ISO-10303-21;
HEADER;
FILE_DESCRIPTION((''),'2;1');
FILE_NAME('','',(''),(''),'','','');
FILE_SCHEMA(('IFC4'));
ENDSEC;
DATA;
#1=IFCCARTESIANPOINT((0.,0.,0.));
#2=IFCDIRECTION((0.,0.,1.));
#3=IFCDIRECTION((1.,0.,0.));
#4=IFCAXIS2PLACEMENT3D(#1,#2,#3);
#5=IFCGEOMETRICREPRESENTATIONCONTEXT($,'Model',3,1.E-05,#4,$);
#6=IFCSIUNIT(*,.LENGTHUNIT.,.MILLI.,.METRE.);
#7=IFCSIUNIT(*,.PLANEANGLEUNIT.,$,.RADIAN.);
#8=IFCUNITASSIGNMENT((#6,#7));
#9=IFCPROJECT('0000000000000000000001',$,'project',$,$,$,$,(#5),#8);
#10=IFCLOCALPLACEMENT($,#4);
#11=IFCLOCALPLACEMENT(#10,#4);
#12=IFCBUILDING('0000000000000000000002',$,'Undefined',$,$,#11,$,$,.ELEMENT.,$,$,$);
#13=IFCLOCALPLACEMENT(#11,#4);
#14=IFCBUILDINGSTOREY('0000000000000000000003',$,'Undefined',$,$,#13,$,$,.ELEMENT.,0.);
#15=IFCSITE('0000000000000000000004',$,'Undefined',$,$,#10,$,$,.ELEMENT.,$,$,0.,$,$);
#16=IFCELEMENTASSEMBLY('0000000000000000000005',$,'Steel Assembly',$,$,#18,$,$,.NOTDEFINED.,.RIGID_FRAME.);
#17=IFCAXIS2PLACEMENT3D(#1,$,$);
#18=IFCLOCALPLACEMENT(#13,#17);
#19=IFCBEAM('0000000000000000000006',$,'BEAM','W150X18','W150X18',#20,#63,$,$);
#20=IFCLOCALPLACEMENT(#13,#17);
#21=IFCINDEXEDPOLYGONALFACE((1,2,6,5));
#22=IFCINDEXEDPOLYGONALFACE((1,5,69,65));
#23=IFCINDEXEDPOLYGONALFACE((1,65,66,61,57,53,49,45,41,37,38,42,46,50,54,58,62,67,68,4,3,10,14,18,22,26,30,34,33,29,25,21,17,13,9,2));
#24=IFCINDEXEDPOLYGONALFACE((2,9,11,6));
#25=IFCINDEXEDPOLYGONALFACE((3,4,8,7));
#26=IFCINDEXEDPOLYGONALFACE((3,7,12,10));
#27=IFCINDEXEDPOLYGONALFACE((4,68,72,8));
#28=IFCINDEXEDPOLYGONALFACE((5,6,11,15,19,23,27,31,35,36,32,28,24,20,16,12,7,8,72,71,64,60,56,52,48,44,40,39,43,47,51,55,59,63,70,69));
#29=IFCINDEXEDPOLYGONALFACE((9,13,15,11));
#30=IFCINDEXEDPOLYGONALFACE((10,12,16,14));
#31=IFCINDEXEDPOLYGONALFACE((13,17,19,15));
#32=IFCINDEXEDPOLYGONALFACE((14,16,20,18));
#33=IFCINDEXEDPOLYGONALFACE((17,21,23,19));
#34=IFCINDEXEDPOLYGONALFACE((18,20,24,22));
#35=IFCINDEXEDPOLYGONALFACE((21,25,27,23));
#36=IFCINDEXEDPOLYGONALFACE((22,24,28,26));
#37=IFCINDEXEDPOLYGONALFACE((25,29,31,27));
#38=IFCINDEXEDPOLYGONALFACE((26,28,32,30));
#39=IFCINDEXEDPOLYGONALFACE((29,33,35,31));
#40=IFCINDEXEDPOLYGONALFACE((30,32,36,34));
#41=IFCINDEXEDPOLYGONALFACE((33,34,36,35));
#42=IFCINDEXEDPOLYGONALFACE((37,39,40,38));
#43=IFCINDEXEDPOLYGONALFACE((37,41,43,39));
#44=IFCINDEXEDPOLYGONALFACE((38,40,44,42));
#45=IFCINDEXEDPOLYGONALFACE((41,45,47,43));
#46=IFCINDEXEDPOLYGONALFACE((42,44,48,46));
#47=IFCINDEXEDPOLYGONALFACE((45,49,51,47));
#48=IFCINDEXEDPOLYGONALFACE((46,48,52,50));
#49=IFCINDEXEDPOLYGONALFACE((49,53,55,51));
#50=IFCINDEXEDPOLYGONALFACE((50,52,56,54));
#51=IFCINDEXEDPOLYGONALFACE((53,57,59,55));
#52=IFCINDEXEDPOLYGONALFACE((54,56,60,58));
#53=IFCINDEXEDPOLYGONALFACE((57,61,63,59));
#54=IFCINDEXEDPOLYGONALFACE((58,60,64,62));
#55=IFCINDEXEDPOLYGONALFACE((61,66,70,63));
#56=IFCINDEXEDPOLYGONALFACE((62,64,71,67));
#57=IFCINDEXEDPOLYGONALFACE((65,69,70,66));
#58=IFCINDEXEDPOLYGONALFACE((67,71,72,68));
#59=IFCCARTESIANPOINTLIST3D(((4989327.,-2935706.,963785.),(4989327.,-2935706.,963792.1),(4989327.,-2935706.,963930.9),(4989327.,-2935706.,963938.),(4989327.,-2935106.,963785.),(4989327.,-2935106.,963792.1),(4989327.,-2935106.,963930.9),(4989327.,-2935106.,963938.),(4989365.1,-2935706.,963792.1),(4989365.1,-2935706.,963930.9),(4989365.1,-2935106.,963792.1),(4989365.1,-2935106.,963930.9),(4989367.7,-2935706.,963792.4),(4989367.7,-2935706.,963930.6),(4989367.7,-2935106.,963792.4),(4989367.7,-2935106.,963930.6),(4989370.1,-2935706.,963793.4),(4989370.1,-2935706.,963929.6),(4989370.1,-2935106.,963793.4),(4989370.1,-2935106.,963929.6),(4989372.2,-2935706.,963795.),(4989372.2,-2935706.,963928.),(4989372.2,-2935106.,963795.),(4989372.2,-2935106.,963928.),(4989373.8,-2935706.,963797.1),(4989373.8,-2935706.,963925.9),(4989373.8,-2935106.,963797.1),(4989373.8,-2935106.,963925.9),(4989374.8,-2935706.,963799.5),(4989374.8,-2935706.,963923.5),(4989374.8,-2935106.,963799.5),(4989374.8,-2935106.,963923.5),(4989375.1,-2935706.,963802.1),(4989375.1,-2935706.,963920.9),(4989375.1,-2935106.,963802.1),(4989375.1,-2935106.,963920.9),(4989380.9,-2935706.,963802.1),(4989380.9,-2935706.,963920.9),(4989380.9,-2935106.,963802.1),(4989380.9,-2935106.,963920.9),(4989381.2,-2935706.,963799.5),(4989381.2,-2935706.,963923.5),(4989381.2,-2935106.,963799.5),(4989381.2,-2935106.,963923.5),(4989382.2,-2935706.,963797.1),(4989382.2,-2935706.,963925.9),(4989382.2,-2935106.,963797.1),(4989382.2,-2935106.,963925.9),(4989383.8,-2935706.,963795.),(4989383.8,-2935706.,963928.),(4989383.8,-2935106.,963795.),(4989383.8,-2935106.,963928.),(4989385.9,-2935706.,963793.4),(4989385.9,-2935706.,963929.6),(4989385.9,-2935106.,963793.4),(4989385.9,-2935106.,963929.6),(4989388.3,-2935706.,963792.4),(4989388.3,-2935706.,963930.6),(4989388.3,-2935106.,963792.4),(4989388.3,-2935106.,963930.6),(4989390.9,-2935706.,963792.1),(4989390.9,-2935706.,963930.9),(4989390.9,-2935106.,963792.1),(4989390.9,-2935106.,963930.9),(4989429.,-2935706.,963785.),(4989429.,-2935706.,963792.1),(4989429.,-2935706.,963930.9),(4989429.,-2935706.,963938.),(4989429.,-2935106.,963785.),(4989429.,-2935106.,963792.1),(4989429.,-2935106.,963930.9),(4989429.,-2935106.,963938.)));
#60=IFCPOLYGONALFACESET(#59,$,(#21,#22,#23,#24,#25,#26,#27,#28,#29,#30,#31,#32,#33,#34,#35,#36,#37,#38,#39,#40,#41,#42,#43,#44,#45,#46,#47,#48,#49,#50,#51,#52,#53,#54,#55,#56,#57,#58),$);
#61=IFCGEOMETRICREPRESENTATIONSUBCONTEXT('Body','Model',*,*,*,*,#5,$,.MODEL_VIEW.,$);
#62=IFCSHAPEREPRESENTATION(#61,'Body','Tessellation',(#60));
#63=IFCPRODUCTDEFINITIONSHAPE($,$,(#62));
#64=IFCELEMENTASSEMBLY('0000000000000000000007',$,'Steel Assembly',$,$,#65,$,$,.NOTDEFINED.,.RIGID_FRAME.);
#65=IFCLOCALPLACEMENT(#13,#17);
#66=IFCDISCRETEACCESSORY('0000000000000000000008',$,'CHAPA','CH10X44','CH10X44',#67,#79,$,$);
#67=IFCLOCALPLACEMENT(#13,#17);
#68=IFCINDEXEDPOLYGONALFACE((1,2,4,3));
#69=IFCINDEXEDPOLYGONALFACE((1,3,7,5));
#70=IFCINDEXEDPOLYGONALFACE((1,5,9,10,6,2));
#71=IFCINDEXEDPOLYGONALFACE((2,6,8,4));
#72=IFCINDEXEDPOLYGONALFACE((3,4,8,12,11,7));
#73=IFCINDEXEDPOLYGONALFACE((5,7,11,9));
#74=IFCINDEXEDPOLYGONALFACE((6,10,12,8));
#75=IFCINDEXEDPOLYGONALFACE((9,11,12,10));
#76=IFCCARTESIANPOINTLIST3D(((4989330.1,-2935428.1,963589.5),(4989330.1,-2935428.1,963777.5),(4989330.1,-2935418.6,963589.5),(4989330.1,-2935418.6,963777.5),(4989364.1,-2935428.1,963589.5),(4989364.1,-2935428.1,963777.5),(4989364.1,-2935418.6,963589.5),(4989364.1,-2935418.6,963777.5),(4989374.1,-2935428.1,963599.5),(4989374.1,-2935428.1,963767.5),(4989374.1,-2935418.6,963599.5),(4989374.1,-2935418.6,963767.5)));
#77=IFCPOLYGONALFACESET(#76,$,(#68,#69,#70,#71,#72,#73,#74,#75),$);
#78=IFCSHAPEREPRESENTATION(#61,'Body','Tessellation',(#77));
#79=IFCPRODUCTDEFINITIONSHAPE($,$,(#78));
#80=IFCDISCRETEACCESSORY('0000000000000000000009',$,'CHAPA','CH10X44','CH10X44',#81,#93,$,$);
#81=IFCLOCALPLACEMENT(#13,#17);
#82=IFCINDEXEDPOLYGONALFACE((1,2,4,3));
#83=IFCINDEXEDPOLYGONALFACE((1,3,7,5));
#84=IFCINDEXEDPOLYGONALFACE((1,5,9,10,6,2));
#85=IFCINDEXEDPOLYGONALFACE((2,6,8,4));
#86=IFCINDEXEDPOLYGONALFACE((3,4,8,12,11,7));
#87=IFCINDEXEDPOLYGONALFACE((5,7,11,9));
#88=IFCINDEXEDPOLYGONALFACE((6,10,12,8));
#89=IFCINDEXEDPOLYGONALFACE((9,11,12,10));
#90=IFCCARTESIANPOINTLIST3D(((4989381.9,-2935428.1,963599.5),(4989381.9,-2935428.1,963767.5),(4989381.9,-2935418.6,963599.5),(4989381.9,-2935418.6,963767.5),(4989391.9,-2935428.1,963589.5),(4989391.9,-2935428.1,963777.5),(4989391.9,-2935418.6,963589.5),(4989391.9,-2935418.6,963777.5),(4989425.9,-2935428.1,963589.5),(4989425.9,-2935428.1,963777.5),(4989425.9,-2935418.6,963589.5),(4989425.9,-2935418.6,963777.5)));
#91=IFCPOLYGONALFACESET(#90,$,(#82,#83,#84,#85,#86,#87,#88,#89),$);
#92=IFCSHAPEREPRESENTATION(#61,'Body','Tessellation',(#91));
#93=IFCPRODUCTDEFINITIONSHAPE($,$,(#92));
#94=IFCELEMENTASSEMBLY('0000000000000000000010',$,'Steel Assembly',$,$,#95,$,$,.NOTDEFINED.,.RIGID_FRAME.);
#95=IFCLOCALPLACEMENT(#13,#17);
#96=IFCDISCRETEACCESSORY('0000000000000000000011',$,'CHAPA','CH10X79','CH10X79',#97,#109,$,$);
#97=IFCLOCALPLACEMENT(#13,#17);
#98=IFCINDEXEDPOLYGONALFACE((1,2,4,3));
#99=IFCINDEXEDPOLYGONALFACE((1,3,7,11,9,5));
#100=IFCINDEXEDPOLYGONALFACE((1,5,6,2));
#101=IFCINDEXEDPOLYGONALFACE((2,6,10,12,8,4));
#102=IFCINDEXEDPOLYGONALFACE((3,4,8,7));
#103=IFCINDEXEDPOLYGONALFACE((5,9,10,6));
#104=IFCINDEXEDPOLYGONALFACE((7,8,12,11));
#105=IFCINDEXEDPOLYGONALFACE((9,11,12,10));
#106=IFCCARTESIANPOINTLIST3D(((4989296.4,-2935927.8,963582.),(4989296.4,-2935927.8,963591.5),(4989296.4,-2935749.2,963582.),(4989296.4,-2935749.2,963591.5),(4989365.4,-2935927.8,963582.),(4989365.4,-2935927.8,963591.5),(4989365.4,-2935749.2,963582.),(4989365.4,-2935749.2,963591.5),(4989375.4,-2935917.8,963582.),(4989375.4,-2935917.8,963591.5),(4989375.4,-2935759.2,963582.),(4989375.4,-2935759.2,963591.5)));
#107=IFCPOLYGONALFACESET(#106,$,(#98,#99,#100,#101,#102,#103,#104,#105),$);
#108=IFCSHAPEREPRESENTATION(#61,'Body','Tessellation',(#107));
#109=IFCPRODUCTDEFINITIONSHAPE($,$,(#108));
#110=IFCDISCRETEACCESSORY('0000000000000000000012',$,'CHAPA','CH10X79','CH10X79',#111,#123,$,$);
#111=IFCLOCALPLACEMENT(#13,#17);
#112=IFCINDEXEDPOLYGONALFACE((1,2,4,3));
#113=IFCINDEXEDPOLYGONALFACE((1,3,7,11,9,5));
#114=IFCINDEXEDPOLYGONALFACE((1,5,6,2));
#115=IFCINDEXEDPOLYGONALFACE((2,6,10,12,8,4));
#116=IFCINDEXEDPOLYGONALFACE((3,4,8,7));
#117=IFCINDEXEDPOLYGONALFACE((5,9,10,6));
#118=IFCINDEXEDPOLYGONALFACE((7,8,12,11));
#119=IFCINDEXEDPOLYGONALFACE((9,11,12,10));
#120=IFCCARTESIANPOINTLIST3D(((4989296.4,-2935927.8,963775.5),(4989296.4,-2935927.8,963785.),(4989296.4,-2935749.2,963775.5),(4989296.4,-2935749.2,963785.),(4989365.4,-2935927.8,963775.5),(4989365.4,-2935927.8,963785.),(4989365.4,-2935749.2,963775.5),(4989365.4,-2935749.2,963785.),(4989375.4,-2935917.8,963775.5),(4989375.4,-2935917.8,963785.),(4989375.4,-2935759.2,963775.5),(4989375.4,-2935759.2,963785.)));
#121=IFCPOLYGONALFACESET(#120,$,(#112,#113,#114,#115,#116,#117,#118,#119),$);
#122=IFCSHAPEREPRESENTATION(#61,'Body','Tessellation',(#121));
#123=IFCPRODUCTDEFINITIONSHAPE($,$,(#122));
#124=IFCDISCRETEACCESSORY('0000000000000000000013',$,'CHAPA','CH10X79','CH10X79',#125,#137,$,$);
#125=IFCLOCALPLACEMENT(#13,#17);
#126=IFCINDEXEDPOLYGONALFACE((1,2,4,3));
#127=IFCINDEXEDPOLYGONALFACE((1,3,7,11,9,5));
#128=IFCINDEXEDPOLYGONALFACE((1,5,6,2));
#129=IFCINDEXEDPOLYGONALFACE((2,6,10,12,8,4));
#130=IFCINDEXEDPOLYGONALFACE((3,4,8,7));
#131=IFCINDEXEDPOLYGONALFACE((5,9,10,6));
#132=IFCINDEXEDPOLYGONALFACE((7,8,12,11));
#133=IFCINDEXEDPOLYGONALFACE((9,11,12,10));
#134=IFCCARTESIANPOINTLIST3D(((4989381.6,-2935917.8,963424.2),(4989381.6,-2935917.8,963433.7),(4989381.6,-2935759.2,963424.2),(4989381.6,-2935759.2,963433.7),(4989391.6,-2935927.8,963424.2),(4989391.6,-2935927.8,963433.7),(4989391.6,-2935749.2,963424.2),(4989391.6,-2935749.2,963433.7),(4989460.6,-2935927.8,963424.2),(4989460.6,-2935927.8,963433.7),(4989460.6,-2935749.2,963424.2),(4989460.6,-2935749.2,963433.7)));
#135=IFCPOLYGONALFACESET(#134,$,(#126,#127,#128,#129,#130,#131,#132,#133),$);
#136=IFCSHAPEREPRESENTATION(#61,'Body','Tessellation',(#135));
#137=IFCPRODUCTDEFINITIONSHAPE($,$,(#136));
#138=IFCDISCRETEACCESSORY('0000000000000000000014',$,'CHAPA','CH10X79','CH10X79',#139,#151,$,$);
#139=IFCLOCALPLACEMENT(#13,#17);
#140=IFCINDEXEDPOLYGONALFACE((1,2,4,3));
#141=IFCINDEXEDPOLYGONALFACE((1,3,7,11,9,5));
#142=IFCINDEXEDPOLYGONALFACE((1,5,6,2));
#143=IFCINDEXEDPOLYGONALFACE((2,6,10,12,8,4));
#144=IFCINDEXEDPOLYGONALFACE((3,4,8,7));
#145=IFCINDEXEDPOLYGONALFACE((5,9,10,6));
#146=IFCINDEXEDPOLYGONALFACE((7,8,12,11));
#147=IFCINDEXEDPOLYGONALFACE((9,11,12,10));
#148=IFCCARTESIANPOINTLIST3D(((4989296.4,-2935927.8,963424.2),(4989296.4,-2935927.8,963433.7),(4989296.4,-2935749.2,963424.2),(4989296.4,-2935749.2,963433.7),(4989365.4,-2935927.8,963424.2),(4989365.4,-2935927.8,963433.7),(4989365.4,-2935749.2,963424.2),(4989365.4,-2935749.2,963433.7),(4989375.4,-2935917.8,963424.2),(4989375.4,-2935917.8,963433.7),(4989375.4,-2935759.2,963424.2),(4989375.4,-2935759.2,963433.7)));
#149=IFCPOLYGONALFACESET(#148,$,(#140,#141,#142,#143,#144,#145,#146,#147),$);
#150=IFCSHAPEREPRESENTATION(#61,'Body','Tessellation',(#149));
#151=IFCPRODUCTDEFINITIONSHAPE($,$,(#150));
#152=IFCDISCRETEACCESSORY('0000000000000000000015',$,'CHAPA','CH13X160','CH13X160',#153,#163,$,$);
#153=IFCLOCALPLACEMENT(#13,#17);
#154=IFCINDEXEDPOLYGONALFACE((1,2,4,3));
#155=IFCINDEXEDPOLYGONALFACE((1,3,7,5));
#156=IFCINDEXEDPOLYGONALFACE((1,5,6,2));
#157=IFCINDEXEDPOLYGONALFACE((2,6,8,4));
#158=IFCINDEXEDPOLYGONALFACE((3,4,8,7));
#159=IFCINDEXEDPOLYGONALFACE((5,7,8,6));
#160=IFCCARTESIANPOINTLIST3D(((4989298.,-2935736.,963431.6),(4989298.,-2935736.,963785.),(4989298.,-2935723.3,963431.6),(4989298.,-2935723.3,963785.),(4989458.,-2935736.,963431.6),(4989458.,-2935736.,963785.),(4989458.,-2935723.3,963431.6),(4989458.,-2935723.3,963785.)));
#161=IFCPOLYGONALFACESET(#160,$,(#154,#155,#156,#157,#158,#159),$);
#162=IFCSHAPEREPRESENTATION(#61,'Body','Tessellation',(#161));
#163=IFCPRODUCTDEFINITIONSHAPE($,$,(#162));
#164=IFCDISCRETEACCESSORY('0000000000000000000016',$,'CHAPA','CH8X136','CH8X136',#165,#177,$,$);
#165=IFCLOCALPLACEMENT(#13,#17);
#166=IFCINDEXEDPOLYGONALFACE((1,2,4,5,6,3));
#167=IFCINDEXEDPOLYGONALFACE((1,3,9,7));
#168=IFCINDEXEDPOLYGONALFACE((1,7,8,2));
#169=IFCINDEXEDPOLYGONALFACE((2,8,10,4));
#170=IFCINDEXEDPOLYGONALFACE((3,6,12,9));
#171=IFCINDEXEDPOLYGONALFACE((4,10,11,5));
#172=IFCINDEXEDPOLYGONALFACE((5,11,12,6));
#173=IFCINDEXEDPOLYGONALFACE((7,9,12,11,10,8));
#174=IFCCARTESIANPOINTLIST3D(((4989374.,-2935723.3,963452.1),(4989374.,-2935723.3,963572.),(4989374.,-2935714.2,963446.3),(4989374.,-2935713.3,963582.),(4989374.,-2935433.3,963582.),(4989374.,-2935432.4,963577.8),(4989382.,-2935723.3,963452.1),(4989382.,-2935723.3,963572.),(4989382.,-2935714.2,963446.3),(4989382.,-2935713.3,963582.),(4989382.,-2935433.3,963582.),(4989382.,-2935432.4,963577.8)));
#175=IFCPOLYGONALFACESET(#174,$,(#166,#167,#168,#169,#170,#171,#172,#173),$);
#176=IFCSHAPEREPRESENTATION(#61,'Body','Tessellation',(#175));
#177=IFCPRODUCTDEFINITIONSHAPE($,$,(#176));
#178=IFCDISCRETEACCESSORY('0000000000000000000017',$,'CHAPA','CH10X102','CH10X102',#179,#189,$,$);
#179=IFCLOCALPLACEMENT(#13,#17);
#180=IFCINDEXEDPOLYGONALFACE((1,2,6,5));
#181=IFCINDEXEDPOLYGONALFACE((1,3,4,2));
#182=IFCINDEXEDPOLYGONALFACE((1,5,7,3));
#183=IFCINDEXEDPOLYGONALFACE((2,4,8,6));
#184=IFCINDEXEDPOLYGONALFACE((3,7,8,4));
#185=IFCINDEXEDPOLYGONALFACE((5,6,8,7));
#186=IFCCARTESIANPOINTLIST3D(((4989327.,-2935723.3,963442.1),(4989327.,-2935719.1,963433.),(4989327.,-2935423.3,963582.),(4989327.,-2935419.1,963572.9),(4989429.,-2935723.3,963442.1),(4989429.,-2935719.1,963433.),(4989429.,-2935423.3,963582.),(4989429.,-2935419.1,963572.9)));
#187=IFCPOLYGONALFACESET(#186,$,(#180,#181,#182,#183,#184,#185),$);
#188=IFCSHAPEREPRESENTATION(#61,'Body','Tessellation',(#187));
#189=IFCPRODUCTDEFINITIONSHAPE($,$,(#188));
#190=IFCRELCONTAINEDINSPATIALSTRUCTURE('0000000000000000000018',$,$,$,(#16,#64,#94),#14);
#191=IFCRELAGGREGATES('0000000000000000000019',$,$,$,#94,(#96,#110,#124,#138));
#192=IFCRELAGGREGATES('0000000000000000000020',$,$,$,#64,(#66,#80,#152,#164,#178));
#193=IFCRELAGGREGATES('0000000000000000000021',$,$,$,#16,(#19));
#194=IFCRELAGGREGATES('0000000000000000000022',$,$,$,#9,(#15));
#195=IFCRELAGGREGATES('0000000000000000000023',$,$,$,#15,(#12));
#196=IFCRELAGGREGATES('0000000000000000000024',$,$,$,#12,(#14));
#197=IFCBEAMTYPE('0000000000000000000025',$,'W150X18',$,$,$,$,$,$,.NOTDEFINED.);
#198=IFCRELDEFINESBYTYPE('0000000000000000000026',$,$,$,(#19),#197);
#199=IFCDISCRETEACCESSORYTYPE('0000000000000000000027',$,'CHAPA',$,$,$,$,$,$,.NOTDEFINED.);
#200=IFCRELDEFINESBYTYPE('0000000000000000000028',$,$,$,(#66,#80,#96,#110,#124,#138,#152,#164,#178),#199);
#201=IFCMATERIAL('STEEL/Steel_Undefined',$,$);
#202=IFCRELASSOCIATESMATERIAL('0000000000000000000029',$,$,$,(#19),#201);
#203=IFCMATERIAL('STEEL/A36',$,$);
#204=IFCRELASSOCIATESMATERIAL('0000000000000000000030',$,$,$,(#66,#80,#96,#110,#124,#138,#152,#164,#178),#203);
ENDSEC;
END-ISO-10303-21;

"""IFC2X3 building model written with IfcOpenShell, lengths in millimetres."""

from ifc_helpers import new_model, si_unit, frame, origin_with_axes, origin_2d_with_axis, place, context, subcontext, project, spatial, polyline, rectangle, i_section, outline, extrude, material, type_object, element, aggregate, save


model = new_model("IFC2X3")

# Units and contexts
model_context = context("Model", 3, precision=1e-05, world=origin_with_axes())
body_context = subcontext(model_context, "Body", "Model", "MODEL_VIEW")
ifc_project = project(units=[si_unit("LENGTHUNIT", "METRE", prefix="MILLI"), si_unit("PLANEANGLEUNIT", "RADIAN")], contexts=[model_context])

# Site, building, storey
site_placement = place(None, origin_with_axes())
site = spatial("IfcSite", under=ifc_project, at=site_placement, Name="Undefined", CompositionType="ELEMENT", RefElevation=0.0)
building_placement = place(site_placement, origin_with_axes())
building = spatial("IfcBuilding", under=site, at=building_placement, Name="Undefined", CompositionType="ELEMENT")
storey_placement = place(building_placement, origin_with_axes())
storey = spatial("IfcBuildingStorey", under=building, at=storey_placement, Name="Undefined", CompositionType="ELEMENT", Elevation=0.0)

# Element assembly, beam
assembly_1_placement = place(storey_placement, origin_with_axes())
assembly_1 = element("IfcElementAssembly", 1, at=assembly_1_placement, inside=storey, Name="Steel Assembly", AssemblyPlace="NOTDEFINED", PredefinedType="RIGID_FRAME")
ifc_material_1 = material(Name="STEEL/Steel_Undefined")
beam_type = type_object("IfcBeamType", Name="W150X18", PredefinedType="NOTDEFINED")
beam_placement = place(assembly_1_placement, frame((4989378.0, -2935106.0, 963861.5), z_axis=(0.0, 0.0, -1.0), x_axis=(0.0, -1.0, 0.0)))
beam = element("IfcBeam", 2, at=beam_placement, type_object=beam_type, material=ifc_material_1, Name="BEAM", Description="W150X18", ObjectType="W150X18", context=body_context, shape_type="SweptSolid", body=[
    extrude(i_section(OverallWidth=102.0, OverallDepth=153.0, WebThickness=5.8, FlangeThickness=7.1, FilletRadius=10.0, at=origin_2d_with_axis()), frame((600.0, 0.0, 0.0), z_axis=(-1.0, 0.0, 0.0), x_axis=(0.0, -1.0, 0.0)), (0.0, 0.0, 1.0), 600.0),
])

# Element assemblies, discrete accessories
assembly_2_placement = place(storey_placement, origin_with_axes())
assembly_2 = element("IfcElementAssembly", 3, at=assembly_2_placement, inside=storey, Name="Steel Assembly", AssemblyPlace="NOTDEFINED", PredefinedType="RIGID_FRAME")
ifc_material_2 = material(Name="STEEL/A36")
discrete_accessory_type_1 = type_object("IfcDiscreteAccessoryType", Name="CHAPA")
discrete_accessory_1_placement = place(assembly_2_placement, frame((4989374.1, -2935423.3, 963589.5), z_axis=(0.0, 1.0, 0.0), x_axis=(-1.0, 0.0, 0.0)))
discrete_accessory_1 = element("IfcDiscreteAccessory", 4, at=discrete_accessory_1_placement, type_object=discrete_accessory_type_1, material=ifc_material_2, Name="CHAPA", Description="CH10X44", ObjectType="CH10X44", context=body_context, shape_type="SweptSolid", body=[
    extrude(outline(polyline([(0.0, 10.0), (10.0, 0.0), (44.0, 0.0), (44.0, 188.0), (10.0, 188.0), (0.0, 178.0), (0.0, 10.0)])), frame((0.0, 0.0, -4.8), z_axis=(0.0, 0.0, 1.0), x_axis=(1.0, 0.0, 0.0)), (0.0, 0.0, 1.0), 9.5),
])
discrete_accessory_2_placement = place(assembly_2_placement, frame((4989381.9, -2935423.3, 963589.5), z_axis=(0.0, -1.0, 0.0), x_axis=(1.0, 0.0, 0.0)))
discrete_accessory_2 = element("IfcDiscreteAccessory", 5, at=discrete_accessory_2_placement, type_object=discrete_accessory_type_1, material=ifc_material_2, Name="CHAPA", Description="CH10X44", ObjectType="CH10X44", context=body_context, shape_type="SweptSolid", body=[
    extrude(outline(polyline([(0.0, 10.0), (10.0, 0.0), (44.0, 0.0), (44.0, 188.0), (10.0, 188.0), (0.0, 178.0), (0.0, 10.0)])), frame((0.0, 0.0, -4.8), z_axis=(0.0, 0.0, 1.0), x_axis=(1.0, 0.0, 0.0)), (0.0, 0.0, 1.0), 9.5),
])
assembly_3_placement = place(storey_placement, origin_with_axes())
assembly_3 = element("IfcElementAssembly", 6, at=assembly_3_placement, inside=storey, Name="Steel Assembly", AssemblyPlace="NOTDEFINED", PredefinedType="RIGID_FRAME")
discrete_accessory_3_placement = place(assembly_3_placement, frame((4989296.4, -2935749.2, 963586.8), z_axis=(0.0, 0.0, -1.0), x_axis=(1.0, 0.0, 0.0)))
discrete_accessory_3 = element("IfcDiscreteAccessory", 7, at=discrete_accessory_3_placement, type_object=discrete_accessory_type_1, material=ifc_material_2, Name="CHAPA", Description="CH10X79", ObjectType="CH10X79", context=body_context, shape_type="SweptSolid", body=[
    extrude(outline(polyline([(0.0, 0.0), (69.0, 0.0), (79.0, 10.0), (79.0, 168.6), (69.0, 178.6), (0.0, 178.6), (0.0, 0.0)])), frame((0.0, 0.0, -4.8), z_axis=(0.0, 0.0, 1.0), x_axis=(1.0, 0.0, 0.0)), (0.0, 0.0, 1.0), 9.5),
])
discrete_accessory_4_placement = place(assembly_3_placement, frame((4989296.4, -2935749.2, 963780.3), z_axis=(0.0, 0.0, -1.0), x_axis=(1.0, 0.0, 0.0)))
discrete_accessory_4 = element("IfcDiscreteAccessory", 8, at=discrete_accessory_4_placement, type_object=discrete_accessory_type_1, material=ifc_material_2, Name="CHAPA", Description="CH10X79", ObjectType="CH10X79", context=body_context, shape_type="SweptSolid", body=[
    extrude(outline(polyline([(0.0, 0.0), (69.0, 0.0), (79.0, 10.0), (79.0, 168.6), (69.0, 178.6), (0.0, 178.6), (0.0, 0.0)])), frame((0.0, 0.0, -4.8), z_axis=(0.0, 0.0, 1.0), x_axis=(1.0, 0.0, 0.0)), (0.0, 0.0, 1.0), 9.5),
])
discrete_accessory_5_placement = place(assembly_3_placement, frame((4989460.6, -2935749.2, 963429.0), z_axis=(0.0, 0.0, 1.0), x_axis=(-1.0, 0.0, 0.0)))
discrete_accessory_5 = element("IfcDiscreteAccessory", 9, at=discrete_accessory_5_placement, type_object=discrete_accessory_type_1, material=ifc_material_2, Name="CHAPA", Description="CH10X79", ObjectType="CH10X79", context=body_context, shape_type="SweptSolid", body=[
    extrude(outline(polyline([(0.0, 0.0), (69.0, 0.0), (79.0, 10.0), (79.0, 168.6), (69.0, 178.6), (0.0, 178.6), (0.0, 0.0)])), frame((0.0, 0.0, -4.8), z_axis=(0.0, 0.0, 1.0), x_axis=(1.0, 0.0, 0.0)), (0.0, 0.0, 1.0), 9.5),
])
discrete_accessory_6_placement = place(assembly_3_placement, frame((4989296.4, -2935749.2, 963429.0), z_axis=(0.0, 0.0, -1.0), x_axis=(1.0, 0.0, 0.0)))
discrete_accessory_6 = element("IfcDiscreteAccessory", 10, at=discrete_accessory_6_placement, type_object=discrete_accessory_type_1, material=ifc_material_2, Name="CHAPA", Description="CH10X79", ObjectType="CH10X79", context=body_context, shape_type="SweptSolid", body=[
    extrude(outline(polyline([(0.0, 0.0), (69.0, 0.0), (79.0, 10.0), (79.0, 168.6), (69.0, 178.6), (0.0, 178.6), (0.0, 0.0)])), frame((0.0, 0.0, -4.8), z_axis=(0.0, 0.0, 1.0), x_axis=(1.0, 0.0, 0.0)), (0.0, 0.0, 1.0), 9.5),
])
aggregate(assembly_3, [discrete_accessory_3, discrete_accessory_4, discrete_accessory_5, discrete_accessory_6])

# Discrete accessories
discrete_accessory_7_placement = place(assembly_2_placement, frame((4989378.0, -2935729.7, 963431.6), z_axis=(0.0, 1.0, 0.0), x_axis=(0.0, 0.0, 1.0)))
discrete_accessory_7 = element("IfcDiscreteAccessory", 11, at=discrete_accessory_7_placement, type_object=discrete_accessory_type_1, material=ifc_material_2, Name="CHAPA", Description="CH13X160", ObjectType="CH13X160", context=body_context, shape_type="SweptSolid", body=[
    extrude(outline(polyline([(0.0, -80.0), (0.0, 80.0), (353.4, 80.0), (353.4, -80.0), (0.0, -80.0)])), frame((0.0, 0.0, -6.3), z_axis=(0.0, 0.0, 1.0), x_axis=(1.0, 0.0, 0.0)), (0.0, 0.0, 1.0), 12.7),
])
discrete_accessory_8_placement = place(assembly_2_placement, frame((4989378.0, -2935723.3, 963442.1), z_axis=(-1.0, 0.0, 0.0), x_axis=(0.0, 0.0, 1.0)))
discrete_accessory_8 = element("IfcDiscreteAccessory", 12, at=discrete_accessory_8_placement, type_object=discrete_accessory_type_1, material=ifc_material_2, Name="CHAPA", Description="CH8X136", ObjectType="CH8X136", context=body_context, shape_type="SweptSolid", body=[
    extrude(outline(polyline([(4.2, 9.1), (10.0, 0.0), (129.9, 0.0), (139.9, 10.0), (139.9, 290.0), (135.7, 290.9), (4.2, 9.1)])), frame((0.0, 0.0, -4.0), z_axis=(0.0, 0.0, 1.0), x_axis=(1.0, 0.0, 0.0)), (0.0, 0.0, 1.0), 8.0),
])
discrete_accessory_9_placement = place(assembly_2_placement, frame((4989378.0, -2935721.2, 963437.6), z_axis=(1.0, 0.0, 0.0), x_axis=(0.0, 0.906308, 0.422618)))
discrete_accessory_9 = element("IfcDiscreteAccessory", 13, at=discrete_accessory_9_placement, type_object=discrete_accessory_type_1, material=ifc_material_2, Name="CHAPA", Description="CH10X102", ObjectType="CH10X102", context=body_context, shape_type="SweptSolid", body=[
    extrude(rectangle(XDim=10.0, YDim=102.0, at=origin_2d_with_axis()), frame((331.0, 0.0, 0.0), z_axis=(-1.0, 0.0, 0.0), x_axis=(0.0, -1.0, 0.0)), (0.0, 0.0, 1.0), 331.0),
])

aggregate(assembly_2, [discrete_accessory_1, discrete_accessory_2, discrete_accessory_7, discrete_accessory_8, discrete_accessory_9])

aggregate(assembly_1, [beam])

save(model, "model.ifc")
